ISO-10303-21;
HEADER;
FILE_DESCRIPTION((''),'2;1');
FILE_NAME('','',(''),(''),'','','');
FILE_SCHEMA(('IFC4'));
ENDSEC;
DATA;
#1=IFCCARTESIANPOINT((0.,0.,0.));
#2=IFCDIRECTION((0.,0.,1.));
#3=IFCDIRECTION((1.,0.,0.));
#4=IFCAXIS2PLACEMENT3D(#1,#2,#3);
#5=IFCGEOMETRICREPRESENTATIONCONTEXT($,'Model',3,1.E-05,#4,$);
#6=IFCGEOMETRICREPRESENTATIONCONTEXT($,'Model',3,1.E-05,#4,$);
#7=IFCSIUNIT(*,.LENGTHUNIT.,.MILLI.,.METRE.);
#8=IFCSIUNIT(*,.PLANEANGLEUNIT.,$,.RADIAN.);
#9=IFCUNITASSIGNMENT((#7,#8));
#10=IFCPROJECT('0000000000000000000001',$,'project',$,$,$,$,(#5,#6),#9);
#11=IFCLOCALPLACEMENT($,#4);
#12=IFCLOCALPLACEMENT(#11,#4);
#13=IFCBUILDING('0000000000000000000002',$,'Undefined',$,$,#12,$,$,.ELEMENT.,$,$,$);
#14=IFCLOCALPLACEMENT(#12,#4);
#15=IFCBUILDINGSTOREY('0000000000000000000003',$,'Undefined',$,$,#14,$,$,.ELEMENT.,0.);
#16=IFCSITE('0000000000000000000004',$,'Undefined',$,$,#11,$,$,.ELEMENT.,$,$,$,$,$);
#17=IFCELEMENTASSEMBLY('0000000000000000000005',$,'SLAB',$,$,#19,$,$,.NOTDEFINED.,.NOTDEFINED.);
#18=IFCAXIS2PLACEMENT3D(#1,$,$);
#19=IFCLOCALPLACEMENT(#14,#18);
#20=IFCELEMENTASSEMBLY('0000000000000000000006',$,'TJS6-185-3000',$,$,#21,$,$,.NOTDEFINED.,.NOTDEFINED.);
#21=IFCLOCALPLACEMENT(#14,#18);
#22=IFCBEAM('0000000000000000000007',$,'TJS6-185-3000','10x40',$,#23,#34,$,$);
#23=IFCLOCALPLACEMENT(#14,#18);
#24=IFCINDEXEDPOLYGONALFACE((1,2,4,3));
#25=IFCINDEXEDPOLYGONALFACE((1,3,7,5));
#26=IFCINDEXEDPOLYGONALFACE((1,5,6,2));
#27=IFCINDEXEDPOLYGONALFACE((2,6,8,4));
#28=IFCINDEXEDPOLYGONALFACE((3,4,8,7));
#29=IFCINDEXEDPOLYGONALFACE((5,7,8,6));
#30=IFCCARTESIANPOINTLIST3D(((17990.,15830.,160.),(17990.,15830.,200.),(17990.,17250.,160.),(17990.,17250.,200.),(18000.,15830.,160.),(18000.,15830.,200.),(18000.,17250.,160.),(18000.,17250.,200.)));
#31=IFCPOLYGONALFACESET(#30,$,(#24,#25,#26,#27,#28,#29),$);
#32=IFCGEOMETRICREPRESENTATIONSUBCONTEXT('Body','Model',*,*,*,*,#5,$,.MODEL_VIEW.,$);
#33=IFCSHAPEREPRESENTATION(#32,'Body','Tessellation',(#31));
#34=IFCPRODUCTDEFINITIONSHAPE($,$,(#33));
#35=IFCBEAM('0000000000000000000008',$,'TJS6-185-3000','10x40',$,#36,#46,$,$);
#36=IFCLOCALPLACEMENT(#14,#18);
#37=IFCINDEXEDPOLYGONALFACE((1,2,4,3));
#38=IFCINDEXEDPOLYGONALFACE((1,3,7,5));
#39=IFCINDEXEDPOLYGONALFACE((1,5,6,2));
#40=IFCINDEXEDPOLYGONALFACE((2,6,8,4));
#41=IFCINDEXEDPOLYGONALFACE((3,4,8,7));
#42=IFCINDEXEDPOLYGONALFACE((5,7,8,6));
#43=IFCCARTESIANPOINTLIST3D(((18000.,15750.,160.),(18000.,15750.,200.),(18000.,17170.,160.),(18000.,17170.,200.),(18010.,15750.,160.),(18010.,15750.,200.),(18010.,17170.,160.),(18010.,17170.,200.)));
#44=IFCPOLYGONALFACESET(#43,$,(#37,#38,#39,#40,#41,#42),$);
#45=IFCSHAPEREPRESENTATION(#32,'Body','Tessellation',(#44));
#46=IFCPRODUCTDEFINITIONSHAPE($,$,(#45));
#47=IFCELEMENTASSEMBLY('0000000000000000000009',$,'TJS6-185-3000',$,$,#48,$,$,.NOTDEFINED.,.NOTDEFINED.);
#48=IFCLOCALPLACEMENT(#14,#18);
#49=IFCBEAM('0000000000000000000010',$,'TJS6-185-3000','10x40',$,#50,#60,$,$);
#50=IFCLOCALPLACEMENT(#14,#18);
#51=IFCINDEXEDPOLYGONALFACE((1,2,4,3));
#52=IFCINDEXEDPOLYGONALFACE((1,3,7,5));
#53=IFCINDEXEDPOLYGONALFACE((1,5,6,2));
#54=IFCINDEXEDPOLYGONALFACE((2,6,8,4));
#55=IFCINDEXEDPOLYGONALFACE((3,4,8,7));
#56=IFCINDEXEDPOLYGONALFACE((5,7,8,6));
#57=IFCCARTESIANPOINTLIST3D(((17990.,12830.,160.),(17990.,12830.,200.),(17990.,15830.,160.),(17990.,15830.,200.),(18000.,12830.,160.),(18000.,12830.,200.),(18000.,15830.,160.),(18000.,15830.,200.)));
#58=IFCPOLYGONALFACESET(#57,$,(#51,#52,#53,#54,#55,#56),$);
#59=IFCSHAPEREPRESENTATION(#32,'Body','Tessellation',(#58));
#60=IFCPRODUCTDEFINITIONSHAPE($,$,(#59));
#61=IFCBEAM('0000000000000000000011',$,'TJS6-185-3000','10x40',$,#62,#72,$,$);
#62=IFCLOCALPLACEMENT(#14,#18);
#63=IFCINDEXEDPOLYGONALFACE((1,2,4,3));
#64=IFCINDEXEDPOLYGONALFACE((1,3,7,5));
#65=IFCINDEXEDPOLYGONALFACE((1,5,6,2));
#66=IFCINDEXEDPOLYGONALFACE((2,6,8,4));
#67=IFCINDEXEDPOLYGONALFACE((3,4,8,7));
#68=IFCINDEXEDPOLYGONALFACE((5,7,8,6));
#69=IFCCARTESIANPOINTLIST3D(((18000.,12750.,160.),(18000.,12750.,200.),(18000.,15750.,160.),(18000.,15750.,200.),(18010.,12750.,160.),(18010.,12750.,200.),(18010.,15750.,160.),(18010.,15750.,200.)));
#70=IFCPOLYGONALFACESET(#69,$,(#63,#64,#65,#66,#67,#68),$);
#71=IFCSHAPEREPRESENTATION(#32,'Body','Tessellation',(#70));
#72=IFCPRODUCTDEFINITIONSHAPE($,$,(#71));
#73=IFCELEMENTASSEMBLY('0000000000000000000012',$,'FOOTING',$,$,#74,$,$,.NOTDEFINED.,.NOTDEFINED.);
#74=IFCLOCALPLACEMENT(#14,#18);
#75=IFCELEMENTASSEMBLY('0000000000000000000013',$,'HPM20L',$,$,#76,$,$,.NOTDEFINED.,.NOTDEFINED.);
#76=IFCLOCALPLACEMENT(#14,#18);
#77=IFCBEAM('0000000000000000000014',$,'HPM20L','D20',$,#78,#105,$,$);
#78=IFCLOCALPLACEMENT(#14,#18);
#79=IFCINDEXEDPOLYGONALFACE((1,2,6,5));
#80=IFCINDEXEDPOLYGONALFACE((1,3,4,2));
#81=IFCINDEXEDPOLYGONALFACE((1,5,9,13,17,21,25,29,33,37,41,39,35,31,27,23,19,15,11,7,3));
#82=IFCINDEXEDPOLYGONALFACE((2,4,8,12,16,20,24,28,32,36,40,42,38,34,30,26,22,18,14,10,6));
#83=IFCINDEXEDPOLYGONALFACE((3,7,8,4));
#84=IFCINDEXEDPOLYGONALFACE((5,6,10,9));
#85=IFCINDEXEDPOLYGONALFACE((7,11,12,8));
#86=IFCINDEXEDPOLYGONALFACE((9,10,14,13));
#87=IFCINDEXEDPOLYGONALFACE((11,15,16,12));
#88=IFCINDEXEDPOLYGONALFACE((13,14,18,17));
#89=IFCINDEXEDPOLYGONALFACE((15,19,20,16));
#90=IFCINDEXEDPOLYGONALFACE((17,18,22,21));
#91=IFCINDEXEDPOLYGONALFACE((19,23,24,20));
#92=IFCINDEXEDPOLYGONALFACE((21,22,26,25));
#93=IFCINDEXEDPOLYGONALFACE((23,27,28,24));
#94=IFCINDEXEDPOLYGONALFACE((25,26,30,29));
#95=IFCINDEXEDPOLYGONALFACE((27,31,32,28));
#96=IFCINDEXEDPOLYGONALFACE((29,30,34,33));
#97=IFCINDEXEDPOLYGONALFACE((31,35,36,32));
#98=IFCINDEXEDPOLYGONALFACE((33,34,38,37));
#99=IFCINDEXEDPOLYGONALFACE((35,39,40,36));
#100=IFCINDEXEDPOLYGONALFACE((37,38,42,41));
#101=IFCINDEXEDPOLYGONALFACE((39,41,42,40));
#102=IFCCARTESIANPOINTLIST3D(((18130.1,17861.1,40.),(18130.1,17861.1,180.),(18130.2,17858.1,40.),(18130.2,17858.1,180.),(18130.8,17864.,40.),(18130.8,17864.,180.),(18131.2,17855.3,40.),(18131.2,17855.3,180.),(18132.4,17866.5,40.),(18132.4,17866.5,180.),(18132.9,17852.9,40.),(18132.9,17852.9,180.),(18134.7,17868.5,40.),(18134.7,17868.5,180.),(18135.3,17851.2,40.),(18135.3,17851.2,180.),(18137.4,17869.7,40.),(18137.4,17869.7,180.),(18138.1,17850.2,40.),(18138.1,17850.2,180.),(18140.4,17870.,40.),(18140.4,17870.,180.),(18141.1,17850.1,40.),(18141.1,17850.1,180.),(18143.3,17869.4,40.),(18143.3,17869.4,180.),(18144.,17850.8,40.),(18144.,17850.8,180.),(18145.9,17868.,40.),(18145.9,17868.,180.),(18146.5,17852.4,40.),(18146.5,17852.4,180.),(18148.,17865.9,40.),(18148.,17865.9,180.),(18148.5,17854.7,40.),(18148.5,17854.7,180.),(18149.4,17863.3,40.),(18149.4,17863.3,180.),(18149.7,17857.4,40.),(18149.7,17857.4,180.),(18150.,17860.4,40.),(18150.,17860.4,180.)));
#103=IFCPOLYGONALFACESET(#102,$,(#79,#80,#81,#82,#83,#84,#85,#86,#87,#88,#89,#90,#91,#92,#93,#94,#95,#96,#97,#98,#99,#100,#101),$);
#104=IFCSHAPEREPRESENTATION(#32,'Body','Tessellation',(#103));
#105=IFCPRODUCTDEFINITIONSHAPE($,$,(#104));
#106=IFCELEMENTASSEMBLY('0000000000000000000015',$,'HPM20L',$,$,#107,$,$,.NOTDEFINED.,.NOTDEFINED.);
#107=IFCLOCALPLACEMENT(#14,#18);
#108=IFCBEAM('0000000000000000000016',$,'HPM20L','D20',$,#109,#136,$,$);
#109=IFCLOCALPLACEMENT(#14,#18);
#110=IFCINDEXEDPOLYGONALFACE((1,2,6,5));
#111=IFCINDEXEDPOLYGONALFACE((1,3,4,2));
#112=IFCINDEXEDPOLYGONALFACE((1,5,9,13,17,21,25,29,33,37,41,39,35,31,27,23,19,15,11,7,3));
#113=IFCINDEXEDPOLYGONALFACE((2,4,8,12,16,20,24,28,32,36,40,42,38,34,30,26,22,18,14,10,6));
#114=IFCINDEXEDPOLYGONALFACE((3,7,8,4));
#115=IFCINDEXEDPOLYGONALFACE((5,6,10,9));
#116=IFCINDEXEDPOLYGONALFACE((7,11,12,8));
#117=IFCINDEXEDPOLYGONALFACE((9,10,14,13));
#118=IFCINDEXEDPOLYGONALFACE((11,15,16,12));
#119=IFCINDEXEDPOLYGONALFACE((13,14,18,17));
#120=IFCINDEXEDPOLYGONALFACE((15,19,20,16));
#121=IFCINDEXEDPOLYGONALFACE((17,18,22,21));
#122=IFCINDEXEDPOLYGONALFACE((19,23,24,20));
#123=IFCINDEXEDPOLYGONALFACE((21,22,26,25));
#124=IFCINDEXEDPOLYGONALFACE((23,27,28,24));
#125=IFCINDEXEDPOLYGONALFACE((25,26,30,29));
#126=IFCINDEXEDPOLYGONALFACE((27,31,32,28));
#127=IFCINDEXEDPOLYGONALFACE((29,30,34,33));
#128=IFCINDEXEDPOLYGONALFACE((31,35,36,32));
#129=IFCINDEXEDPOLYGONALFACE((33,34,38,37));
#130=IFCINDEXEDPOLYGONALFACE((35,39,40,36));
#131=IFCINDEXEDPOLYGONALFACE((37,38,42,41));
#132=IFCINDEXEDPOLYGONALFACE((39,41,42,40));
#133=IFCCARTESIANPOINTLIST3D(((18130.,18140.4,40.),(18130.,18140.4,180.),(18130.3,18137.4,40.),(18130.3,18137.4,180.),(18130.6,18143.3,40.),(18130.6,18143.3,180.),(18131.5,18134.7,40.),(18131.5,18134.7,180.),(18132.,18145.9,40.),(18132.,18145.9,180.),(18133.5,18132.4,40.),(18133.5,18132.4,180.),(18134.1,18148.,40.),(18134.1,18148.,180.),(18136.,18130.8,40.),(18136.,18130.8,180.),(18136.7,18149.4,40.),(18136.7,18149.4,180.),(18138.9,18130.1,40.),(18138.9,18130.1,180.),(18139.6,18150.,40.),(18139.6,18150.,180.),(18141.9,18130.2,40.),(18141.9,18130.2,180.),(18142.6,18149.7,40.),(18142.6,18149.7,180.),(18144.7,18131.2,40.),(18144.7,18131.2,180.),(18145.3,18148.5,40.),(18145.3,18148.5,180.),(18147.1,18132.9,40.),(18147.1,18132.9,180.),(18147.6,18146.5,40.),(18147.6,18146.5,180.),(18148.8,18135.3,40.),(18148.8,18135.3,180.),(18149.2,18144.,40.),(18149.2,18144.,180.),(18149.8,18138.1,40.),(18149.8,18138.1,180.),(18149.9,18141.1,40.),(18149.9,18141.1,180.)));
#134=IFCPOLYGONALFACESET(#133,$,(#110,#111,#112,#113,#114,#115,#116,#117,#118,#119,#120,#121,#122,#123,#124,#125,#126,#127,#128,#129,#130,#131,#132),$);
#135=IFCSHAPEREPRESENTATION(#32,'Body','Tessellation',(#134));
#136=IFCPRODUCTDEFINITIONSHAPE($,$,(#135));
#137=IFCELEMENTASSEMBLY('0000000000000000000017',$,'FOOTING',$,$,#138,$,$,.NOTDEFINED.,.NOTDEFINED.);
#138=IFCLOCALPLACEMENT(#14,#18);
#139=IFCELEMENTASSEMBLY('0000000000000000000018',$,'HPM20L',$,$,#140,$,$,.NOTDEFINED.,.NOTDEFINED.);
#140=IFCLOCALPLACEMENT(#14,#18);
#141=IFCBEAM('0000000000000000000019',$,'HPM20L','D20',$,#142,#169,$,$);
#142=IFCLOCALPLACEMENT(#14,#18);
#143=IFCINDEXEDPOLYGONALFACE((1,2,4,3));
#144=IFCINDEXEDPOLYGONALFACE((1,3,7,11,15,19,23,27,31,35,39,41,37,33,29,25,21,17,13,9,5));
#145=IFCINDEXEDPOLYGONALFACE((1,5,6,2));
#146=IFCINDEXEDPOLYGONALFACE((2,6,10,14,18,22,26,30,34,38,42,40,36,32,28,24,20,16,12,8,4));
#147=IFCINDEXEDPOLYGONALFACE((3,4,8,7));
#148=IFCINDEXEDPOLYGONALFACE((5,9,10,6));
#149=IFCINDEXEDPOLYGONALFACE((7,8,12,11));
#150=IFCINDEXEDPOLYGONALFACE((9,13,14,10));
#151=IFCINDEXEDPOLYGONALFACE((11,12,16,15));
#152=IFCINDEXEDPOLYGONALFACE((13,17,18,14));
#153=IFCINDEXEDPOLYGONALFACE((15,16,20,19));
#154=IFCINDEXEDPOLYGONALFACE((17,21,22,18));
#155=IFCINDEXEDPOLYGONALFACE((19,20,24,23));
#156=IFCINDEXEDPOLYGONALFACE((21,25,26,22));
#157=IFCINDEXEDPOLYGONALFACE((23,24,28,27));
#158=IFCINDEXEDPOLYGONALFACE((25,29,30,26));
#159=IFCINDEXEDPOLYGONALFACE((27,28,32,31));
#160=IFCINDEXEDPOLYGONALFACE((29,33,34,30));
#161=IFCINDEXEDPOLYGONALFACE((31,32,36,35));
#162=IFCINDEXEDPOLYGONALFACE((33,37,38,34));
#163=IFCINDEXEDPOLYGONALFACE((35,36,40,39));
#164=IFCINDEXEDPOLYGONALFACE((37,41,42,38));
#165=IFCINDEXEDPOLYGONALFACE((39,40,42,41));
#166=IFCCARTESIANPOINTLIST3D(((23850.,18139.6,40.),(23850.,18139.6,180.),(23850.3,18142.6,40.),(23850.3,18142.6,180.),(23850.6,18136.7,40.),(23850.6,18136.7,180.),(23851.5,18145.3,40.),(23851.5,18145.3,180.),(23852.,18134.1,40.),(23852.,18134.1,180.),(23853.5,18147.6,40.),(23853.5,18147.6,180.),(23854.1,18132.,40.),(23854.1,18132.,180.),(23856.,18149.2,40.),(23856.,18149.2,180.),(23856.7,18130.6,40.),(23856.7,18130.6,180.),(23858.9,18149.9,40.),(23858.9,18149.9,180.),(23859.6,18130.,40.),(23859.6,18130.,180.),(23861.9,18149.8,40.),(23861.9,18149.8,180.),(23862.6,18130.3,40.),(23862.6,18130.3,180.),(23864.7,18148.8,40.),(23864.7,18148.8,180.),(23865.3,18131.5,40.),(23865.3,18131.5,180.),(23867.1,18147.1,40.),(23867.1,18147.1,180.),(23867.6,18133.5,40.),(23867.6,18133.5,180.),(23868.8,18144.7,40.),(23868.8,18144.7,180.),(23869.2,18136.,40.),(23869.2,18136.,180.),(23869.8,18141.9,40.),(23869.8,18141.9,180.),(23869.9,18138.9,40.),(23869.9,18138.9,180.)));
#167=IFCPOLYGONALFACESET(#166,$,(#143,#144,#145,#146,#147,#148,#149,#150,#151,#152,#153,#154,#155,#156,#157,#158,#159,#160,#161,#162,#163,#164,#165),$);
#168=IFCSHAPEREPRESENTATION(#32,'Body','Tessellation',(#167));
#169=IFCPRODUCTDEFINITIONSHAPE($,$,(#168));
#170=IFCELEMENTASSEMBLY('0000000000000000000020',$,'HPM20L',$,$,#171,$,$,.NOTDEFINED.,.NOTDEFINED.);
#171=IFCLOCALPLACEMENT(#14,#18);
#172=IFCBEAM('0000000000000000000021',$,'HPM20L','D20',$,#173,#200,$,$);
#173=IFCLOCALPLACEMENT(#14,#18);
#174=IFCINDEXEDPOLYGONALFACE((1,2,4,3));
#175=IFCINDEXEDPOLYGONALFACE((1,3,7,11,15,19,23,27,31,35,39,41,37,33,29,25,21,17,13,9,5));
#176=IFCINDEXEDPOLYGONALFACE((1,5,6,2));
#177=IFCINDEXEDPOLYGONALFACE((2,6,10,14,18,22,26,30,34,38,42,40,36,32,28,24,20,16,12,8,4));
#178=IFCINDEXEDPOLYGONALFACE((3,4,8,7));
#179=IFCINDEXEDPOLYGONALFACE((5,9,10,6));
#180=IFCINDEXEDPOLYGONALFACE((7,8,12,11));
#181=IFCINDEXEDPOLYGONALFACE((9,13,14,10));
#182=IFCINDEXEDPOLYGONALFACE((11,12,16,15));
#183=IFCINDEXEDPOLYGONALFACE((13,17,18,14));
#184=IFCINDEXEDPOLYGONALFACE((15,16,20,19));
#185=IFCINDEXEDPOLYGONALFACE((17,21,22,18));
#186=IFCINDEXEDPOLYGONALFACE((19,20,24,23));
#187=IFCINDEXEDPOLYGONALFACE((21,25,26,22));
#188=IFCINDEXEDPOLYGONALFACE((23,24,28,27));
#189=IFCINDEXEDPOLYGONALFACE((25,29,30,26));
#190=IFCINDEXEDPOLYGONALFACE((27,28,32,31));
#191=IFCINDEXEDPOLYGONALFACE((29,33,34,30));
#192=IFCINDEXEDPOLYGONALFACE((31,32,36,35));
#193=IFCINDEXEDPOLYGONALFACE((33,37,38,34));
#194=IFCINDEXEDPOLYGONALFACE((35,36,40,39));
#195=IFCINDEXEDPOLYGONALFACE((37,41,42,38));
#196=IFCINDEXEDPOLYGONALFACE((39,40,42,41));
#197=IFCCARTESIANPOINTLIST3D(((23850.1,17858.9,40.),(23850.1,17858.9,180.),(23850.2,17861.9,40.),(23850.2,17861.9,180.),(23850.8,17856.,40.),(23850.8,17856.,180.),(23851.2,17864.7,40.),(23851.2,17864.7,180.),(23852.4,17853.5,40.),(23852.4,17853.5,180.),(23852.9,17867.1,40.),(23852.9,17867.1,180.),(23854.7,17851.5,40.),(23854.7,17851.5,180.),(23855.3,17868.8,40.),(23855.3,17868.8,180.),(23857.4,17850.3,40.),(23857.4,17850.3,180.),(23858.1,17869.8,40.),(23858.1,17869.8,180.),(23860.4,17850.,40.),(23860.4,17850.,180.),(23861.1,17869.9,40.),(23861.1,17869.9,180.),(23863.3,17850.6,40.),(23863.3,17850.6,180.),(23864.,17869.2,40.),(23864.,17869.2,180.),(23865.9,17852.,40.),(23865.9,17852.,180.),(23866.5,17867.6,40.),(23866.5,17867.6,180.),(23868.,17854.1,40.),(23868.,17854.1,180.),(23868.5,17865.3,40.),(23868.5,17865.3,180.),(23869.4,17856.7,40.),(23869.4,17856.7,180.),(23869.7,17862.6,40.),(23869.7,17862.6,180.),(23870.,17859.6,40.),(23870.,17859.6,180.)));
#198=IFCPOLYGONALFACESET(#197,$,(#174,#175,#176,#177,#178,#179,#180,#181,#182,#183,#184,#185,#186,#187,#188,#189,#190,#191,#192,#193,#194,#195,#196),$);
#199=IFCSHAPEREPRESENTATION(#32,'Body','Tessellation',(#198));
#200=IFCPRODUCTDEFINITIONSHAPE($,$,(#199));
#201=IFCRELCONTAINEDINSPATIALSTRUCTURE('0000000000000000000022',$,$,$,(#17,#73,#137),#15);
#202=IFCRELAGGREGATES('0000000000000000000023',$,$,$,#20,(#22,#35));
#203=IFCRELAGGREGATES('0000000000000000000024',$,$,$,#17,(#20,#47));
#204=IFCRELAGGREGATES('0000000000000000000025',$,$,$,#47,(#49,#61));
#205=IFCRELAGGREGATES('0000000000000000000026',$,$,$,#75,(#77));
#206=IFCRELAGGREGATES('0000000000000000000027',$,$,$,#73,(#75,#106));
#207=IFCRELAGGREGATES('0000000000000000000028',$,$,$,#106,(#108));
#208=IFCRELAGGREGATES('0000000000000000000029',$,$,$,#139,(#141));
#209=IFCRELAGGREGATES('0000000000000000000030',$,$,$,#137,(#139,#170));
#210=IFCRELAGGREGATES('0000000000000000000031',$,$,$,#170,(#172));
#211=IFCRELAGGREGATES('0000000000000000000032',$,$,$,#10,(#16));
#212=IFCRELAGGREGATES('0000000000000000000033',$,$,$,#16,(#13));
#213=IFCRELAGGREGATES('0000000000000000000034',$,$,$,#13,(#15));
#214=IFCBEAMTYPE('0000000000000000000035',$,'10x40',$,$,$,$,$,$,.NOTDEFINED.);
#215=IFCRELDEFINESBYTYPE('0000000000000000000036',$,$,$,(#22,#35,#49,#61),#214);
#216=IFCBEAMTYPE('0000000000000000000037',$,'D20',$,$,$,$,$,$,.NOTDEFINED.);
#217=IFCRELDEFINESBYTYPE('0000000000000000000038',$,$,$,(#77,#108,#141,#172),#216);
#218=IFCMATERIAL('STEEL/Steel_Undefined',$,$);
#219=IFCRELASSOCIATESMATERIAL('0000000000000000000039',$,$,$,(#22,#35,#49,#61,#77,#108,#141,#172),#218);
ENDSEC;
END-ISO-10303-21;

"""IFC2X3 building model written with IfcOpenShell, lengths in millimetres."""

from ifc_helpers import new_model, si_unit, frame, origin_with_axes, origin_2d_with_axis, place, context, subcontext, project, spatial, rectangle, circle, extrude, material, type_object, element, aggregate, save


model = new_model("IFC2X3")

# Units and contexts
model_context_1 = context("Model", 3, precision=1e-05, world=origin_with_axes())
model_context_2 = context("Model", 3, precision=1e-05, world=origin_with_axes())
body_context = subcontext(model_context_1, "Body", "Model", "MODEL_VIEW")
ifc_project = project(units=[si_unit("LENGTHUNIT", "METRE", prefix="MILLI"), si_unit("PLANEANGLEUNIT", "RADIAN")], contexts=[model_context_1, model_context_2])

# Site, building, storey
site_placement = place(None, origin_with_axes())
site = spatial("IfcSite", under=ifc_project, at=site_placement, Name="Undefined", CompositionType="ELEMENT")
building_placement = place(site_placement, origin_with_axes())
building = spatial("IfcBuilding", under=site, at=building_placement, Name="Undefined", CompositionType="ELEMENT")
storey_placement = place(building_placement, origin_with_axes())
storey = spatial("IfcBuildingStorey", under=building, at=storey_placement, Name="Undefined", CompositionType="ELEMENT", Elevation=0.0)

# Element assemblies, beams
assembly_1_placement = place(storey_placement, origin_with_axes())
assembly_1 = element("IfcElementAssembly", 1, at=assembly_1_placement, inside=storey, Name="SLAB", AssemblyPlace="NOTDEFINED", PredefinedType="NOTDEFINED")
assembly_2_placement = place(assembly_1_placement, origin_with_axes())
assembly_2 = element("IfcElementAssembly", 2, at=assembly_2_placement, Name="TJS6-185-3000", AssemblyPlace="NOTDEFINED", PredefinedType="NOTDEFINED")
ifc_material_1 = material(Name="STEEL/Steel_Undefined")
beam_type_1 = type_object("IfcBeamType", Name="10x40", PredefinedType="NOTDEFINED")
beam_1_placement = place(assembly_2_placement, frame((17995.0, 15830.0, 180.0), z_axis=(-1.0, 0.0, 0.0), x_axis=(0.0, 1.0, 0.0)))
beam_1 = element("IfcBeam", 3, at=beam_1_placement, type_object=beam_type_1, material=ifc_material_1, Name="TJS6-185-3000", Description="10x40", context=body_context, shape_type="SweptSolid", body=[
    extrude(rectangle(XDim=40.0, YDim=10.0, at=origin_2d_with_axis()), frame((1420.0, 0.0, 0.0), z_axis=(-1.0, 0.0, 0.0), x_axis=(0.0, -1.0, 0.0)), (0.0, 0.0, 1.0), 1420.0),
])
beam_2_placement = place(assembly_2_placement, frame((18005.0, 15750.0, 180.0), z_axis=(-1.0, 0.0, 0.0), x_axis=(0.0, 1.0, 0.0)))
beam_2 = element("IfcBeam", 4, at=beam_2_placement, type_object=beam_type_1, material=ifc_material_1, Name="TJS6-185-3000", Description="10x40", context=body_context, shape_type="SweptSolid", body=[
    extrude(rectangle(XDim=40.0, YDim=10.0, at=origin_2d_with_axis()), frame((1420.0, 0.0, 0.0), z_axis=(-1.0, 0.0, 0.0), x_axis=(0.0, -1.0, 0.0)), (0.0, 0.0, 1.0), 1420.0),
])
aggregate(assembly_2, [beam_1, beam_2])
assembly_3_placement = place(assembly_1_placement, origin_with_axes())
assembly_3 = element("IfcElementAssembly", 5, at=assembly_3_placement, Name="TJS6-185-3000", AssemblyPlace="NOTDEFINED", PredefinedType="NOTDEFINED")
aggregate(assembly_1, [assembly_2, assembly_3])
beam_3_placement = place(assembly_3_placement, frame((17995.0, 12830.0, 180.0), z_axis=(-1.0, 0.0, 0.0), x_axis=(0.0, 1.0, 0.0)))
beam_3 = element("IfcBeam", 6, at=beam_3_placement, type_object=beam_type_1, material=ifc_material_1, Name="TJS6-185-3000", Description="10x40", context=body_context, shape_type="SweptSolid", body=[
    extrude(rectangle(XDim=40.0, YDim=10.0, at=origin_2d_with_axis()), frame((3000.0, 0.0, 0.0), z_axis=(-1.0, 0.0, 0.0), x_axis=(0.0, -1.0, 0.0)), (0.0, 0.0, 1.0), 3000.0),
])
beam_4_placement = place(assembly_3_placement, frame((18005.0, 12750.0, 180.0), z_axis=(-1.0, 0.0, 0.0), x_axis=(0.0, 1.0, 0.0)))
beam_4 = element("IfcBeam", 7, at=beam_4_placement, type_object=beam_type_1, material=ifc_material_1, Name="TJS6-185-3000", Description="10x40", context=body_context, shape_type="SweptSolid", body=[
    extrude(rectangle(XDim=40.0, YDim=10.0, at=origin_2d_with_axis()), frame((3000.0, 0.0, 0.0), z_axis=(-1.0, 0.0, 0.0), x_axis=(0.0, -1.0, 0.0)), (0.0, 0.0, 1.0), 3000.0),
])
aggregate(assembly_3, [beam_3, beam_4])
assembly_4_placement = place(storey_placement, origin_with_axes())
assembly_4 = element("IfcElementAssembly", 8, at=assembly_4_placement, inside=storey, Name="FOOTING", AssemblyPlace="NOTDEFINED", PredefinedType="NOTDEFINED")
assembly_5_placement = place(assembly_4_placement, origin_with_axes())
assembly_5 = element("IfcElementAssembly", 9, at=assembly_5_placement, Name="HPM20L", AssemblyPlace="NOTDEFINED", PredefinedType="NOTDEFINED")
beam_type_2 = type_object("IfcBeamType", Name="D20", PredefinedType="NOTDEFINED")
beam_5_placement = place(assembly_5_placement, frame((18140.0, 17860.0, 180.0), z_axis=(0.707107, -0.707107, 0.0), x_axis=(0.0, 0.0, -1.0)))
beam_5 = element("IfcBeam", 10, at=beam_5_placement, type_object=beam_type_2, material=ifc_material_1, Name="HPM20L", Description="D20", context=body_context, shape_type="SweptSolid", body=[
    extrude(circle(Radius=10.0, at=origin_2d_with_axis()), frame((140.0, 0.0, 0.0), z_axis=(-1.0, 0.0, 0.0), x_axis=(0.0, -1.0, 0.0)), (0.0, 0.0, 1.0), 140.0),
])
aggregate(assembly_5, [beam_5])
assembly_6_placement = place(assembly_4_placement, origin_with_axes())
assembly_6 = element("IfcElementAssembly", 11, at=assembly_6_placement, Name="HPM20L", AssemblyPlace="NOTDEFINED", PredefinedType="NOTDEFINED")
aggregate(assembly_4, [assembly_5, assembly_6])
beam_6_placement = place(assembly_6_placement, frame((18140.0, 18140.0, 180.0), z_axis=(0.707107, 0.707107, 0.0), x_axis=(0.0, 0.0, -1.0)))
beam_6 = element("IfcBeam", 12, at=beam_6_placement, type_object=beam_type_2, material=ifc_material_1, Name="HPM20L", Description="D20", context=body_context, shape_type="SweptSolid", body=[
    extrude(circle(Radius=10.0, at=origin_2d_with_axis()), frame((140.0, 0.0, 0.0), z_axis=(-1.0, 0.0, 0.0), x_axis=(0.0, -1.0, 0.0)), (0.0, 0.0, 1.0), 140.0),
])
aggregate(assembly_6, [beam_6])
assembly_7_placement = place(storey_placement, origin_with_axes())
assembly_7 = element("IfcElementAssembly", 13, at=assembly_7_placement, inside=storey, Name="FOOTING", AssemblyPlace="NOTDEFINED", PredefinedType="NOTDEFINED")
assembly_8_placement = place(assembly_7_placement, origin_with_axes())
assembly_8 = element("IfcElementAssembly", 14, at=assembly_8_placement, Name="HPM20L", AssemblyPlace="NOTDEFINED", PredefinedType="NOTDEFINED")
beam_7_placement = place(assembly_8_placement, frame((23860.0, 18140.0, 180.0), z_axis=(-0.707107, 0.707107, 0.0), x_axis=(0.0, 0.0, -1.0)))
beam_7 = element("IfcBeam", 15, at=beam_7_placement, type_object=beam_type_2, material=ifc_material_1, Name="HPM20L", Description="D20", context=body_context, shape_type="SweptSolid", body=[
    extrude(circle(Radius=10.0, at=origin_2d_with_axis()), frame((140.0, 0.0, 0.0), z_axis=(-1.0, 0.0, 0.0), x_axis=(0.0, -1.0, 0.0)), (0.0, 0.0, 1.0), 140.0),
])
aggregate(assembly_8, [beam_7])
assembly_9_placement = place(assembly_7_placement, origin_with_axes())
assembly_9 = element("IfcElementAssembly", 16, at=assembly_9_placement, Name="HPM20L", AssemblyPlace="NOTDEFINED", PredefinedType="NOTDEFINED")
aggregate(assembly_7, [assembly_8, assembly_9])
beam_8_placement = place(assembly_9_placement, frame((23860.0, 17860.0, 180.0), z_axis=(-0.707107, -0.707107, 0.0), x_axis=(0.0, 0.0, -1.0)))
beam_8 = element("IfcBeam", 17, at=beam_8_placement, type_object=beam_type_2, material=ifc_material_1, Name="HPM20L", Description="D20", context=body_context, shape_type="SweptSolid", body=[
    extrude(circle(Radius=10.0, at=origin_2d_with_axis()), frame((140.0, 0.0, 0.0), z_axis=(-1.0, 0.0, 0.0), x_axis=(0.0, -1.0, 0.0)), (0.0, 0.0, 1.0), 140.0),
])
aggregate(assembly_9, [beam_8])

save(model, "model.ifc")
